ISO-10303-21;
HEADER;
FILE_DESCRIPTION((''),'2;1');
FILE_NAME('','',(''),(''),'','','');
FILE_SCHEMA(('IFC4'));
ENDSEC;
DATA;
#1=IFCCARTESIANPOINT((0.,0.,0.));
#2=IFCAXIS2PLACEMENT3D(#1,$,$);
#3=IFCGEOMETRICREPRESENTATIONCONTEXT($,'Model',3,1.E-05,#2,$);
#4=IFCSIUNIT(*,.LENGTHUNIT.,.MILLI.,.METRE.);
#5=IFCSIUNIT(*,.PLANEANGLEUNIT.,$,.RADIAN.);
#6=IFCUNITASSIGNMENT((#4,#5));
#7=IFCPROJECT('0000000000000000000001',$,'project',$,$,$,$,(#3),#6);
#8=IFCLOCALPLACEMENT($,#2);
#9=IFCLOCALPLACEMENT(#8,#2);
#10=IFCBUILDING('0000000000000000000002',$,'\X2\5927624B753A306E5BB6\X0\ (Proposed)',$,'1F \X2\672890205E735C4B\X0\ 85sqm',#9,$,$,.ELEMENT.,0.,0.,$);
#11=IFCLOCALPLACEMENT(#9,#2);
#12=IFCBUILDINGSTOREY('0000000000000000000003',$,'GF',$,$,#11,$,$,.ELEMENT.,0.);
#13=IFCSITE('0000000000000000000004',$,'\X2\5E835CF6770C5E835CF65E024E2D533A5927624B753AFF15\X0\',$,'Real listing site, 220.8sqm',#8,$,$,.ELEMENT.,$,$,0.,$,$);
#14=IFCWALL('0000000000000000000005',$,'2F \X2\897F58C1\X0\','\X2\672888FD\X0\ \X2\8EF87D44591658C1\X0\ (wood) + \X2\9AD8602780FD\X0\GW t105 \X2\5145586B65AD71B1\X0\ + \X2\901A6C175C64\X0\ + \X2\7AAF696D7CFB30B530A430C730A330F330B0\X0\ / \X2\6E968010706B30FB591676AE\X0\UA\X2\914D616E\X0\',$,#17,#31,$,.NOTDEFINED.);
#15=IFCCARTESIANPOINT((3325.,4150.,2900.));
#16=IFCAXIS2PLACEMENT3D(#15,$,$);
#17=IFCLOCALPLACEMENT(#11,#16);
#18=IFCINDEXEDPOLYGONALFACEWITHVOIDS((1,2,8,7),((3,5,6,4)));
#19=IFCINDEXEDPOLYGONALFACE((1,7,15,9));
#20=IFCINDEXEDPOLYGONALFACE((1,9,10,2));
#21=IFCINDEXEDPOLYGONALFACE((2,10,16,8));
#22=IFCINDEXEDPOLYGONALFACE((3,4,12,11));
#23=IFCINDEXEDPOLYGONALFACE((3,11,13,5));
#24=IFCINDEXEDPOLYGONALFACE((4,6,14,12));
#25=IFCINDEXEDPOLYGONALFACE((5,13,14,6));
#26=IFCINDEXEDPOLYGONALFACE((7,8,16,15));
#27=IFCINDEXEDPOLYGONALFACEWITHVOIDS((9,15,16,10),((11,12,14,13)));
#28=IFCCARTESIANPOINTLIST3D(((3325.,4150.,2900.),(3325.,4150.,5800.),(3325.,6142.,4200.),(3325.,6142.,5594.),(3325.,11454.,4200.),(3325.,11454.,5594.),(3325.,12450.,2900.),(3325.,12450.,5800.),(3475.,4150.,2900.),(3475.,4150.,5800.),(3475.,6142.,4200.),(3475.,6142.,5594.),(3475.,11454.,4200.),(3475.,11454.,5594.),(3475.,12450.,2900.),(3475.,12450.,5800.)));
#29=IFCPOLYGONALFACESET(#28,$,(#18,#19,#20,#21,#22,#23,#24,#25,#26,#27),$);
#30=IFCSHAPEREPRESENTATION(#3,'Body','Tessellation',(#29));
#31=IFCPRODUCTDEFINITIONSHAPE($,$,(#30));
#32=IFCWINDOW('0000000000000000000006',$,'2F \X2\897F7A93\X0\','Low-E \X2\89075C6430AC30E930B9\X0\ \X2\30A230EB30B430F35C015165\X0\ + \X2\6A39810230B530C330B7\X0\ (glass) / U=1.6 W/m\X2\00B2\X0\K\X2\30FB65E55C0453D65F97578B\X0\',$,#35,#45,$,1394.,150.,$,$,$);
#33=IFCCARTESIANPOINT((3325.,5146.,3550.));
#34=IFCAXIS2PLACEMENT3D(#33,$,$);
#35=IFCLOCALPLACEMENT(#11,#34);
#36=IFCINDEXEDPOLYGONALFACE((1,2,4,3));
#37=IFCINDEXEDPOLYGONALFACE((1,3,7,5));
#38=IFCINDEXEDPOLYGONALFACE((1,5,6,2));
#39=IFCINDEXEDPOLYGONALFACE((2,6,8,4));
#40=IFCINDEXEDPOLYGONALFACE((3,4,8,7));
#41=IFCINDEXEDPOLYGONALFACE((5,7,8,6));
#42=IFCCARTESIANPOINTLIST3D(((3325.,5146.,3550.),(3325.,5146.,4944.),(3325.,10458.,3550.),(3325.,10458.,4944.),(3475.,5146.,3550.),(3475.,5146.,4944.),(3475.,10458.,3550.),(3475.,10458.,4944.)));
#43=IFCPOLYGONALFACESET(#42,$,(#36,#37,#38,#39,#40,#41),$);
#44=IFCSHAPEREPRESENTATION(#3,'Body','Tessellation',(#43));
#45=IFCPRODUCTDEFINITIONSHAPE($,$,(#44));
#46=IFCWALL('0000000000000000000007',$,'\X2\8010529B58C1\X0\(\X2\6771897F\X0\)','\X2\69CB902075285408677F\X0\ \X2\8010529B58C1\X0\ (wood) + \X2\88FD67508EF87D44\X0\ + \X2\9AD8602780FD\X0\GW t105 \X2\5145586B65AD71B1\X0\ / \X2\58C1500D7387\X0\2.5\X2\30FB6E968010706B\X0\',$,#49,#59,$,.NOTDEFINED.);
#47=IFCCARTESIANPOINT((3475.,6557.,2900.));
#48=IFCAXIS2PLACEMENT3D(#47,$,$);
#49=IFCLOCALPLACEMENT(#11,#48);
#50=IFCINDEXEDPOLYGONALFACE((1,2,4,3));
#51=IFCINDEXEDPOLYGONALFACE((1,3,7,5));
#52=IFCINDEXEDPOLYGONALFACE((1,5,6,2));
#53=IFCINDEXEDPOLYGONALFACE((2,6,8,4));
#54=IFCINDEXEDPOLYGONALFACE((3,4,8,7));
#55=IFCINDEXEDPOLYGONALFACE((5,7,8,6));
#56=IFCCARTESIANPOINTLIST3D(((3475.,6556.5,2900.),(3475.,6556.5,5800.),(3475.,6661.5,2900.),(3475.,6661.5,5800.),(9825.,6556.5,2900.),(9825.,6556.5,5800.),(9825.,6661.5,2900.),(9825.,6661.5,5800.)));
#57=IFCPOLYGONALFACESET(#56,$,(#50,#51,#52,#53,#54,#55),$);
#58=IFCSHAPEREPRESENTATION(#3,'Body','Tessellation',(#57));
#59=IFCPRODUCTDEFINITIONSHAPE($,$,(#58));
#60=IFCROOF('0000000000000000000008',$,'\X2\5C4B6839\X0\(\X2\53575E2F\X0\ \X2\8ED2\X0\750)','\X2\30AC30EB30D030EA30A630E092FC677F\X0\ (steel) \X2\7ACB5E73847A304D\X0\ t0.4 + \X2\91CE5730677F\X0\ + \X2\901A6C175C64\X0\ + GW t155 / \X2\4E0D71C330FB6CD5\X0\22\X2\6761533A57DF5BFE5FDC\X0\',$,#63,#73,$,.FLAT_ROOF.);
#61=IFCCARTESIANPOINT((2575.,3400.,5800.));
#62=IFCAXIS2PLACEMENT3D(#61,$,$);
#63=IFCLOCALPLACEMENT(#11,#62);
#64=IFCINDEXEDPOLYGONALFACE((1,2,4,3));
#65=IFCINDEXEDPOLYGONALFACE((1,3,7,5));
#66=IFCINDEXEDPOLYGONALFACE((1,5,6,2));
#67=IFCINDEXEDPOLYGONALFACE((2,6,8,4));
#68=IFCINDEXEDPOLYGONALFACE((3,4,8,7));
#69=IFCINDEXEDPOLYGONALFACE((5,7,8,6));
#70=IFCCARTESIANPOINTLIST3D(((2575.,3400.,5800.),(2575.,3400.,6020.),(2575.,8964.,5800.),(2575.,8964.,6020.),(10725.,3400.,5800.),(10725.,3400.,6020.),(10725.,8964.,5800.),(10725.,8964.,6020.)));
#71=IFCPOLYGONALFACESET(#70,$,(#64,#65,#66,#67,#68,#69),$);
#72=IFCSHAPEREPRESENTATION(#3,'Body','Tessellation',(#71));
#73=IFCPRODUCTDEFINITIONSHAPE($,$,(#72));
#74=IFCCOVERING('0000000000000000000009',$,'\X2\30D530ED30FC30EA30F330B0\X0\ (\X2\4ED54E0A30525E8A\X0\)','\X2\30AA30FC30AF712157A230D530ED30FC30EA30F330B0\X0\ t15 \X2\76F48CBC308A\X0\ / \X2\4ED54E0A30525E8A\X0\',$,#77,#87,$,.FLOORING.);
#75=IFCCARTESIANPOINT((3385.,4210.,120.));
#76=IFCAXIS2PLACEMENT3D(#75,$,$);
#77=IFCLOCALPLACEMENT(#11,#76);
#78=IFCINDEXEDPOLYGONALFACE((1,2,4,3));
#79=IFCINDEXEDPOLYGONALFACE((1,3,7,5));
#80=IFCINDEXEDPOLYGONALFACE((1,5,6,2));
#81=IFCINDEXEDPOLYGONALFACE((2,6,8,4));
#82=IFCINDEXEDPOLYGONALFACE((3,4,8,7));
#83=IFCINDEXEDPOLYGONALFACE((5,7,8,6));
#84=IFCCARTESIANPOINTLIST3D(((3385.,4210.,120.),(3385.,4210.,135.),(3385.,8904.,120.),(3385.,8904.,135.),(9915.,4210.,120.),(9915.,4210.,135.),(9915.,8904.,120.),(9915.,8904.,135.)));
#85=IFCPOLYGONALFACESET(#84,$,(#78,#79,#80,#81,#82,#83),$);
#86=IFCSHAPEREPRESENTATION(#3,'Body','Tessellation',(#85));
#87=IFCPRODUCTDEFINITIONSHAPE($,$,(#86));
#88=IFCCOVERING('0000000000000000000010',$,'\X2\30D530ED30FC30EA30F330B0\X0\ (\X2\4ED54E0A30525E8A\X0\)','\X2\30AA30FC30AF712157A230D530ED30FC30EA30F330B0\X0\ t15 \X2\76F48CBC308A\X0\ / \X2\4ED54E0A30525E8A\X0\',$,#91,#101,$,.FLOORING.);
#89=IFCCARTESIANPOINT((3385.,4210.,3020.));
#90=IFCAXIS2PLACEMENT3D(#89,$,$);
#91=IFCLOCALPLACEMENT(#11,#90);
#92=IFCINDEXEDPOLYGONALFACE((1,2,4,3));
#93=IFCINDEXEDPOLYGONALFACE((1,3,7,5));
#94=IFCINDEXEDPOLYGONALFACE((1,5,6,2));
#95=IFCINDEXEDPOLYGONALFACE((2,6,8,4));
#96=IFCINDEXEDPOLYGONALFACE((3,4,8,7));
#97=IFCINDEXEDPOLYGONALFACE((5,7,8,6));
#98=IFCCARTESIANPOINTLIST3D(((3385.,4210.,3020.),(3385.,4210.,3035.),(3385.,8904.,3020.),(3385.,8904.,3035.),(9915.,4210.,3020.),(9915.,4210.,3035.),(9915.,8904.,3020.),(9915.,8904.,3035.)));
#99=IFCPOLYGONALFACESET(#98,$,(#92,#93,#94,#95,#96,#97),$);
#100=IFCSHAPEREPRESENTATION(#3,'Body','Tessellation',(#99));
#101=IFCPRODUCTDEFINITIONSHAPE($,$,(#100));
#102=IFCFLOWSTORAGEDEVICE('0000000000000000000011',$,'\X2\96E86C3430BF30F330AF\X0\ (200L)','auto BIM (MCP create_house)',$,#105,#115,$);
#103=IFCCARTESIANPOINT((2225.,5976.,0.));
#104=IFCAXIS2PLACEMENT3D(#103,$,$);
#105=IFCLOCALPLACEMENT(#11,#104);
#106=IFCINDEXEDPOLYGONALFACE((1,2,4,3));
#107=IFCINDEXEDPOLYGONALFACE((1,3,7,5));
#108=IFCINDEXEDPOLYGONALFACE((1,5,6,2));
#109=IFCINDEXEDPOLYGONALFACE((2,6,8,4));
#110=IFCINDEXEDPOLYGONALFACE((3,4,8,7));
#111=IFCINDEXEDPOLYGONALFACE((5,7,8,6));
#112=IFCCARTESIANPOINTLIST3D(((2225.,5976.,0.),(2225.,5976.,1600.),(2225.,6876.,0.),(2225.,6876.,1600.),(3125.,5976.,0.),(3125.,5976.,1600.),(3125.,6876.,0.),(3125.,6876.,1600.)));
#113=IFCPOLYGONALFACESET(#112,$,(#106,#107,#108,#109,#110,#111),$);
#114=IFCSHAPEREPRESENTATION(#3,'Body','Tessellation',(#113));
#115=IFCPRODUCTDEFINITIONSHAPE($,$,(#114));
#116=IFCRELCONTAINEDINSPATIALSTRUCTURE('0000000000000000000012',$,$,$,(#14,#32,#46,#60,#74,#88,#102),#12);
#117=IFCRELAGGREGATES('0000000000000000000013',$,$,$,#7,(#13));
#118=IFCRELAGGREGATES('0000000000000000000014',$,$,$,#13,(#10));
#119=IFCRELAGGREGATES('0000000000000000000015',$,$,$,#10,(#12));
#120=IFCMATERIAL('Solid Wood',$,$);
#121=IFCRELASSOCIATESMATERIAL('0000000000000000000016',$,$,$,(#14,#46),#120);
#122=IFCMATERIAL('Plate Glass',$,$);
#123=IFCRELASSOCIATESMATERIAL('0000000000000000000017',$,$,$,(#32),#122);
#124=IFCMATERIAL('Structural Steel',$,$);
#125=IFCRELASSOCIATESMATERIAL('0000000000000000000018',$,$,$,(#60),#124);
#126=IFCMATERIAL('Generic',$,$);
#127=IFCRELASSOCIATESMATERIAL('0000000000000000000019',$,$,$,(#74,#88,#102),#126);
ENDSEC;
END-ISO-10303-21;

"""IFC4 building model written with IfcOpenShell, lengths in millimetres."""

from ifc_helpers import new_model, si_unit, frame, frame_2d, origin, place, context, project, spatial, rectangle, extrude, material, element, fill, save


model = new_model("IFC4")

# Units and contexts
model_context = context("Model", 3, precision=1e-05, world=origin())
ifc_project = project(units=[si_unit("LENGTHUNIT", "METRE", prefix="MILLI"), si_unit("PLANEANGLEUNIT", "RADIAN")], contexts=[model_context])

# Site, building, storey
site_placement = place(None, origin())
site = spatial("IfcSite", under=ifc_project, at=site_placement, Name="広島県広島市中区大手町５", ObjectType="Real listing site, 220.8sqm", CompositionType="ELEMENT", RefElevation=0.0)
building_placement = place(site_placement, origin())
building = spatial("IfcBuilding", under=site, at=building_placement, Name="大手町の家 (Proposed)", ObjectType="1F 木造平屋 85sqm", CompositionType="ELEMENT", ElevationOfRefHeight=0.0, ElevationOfTerrain=0.0)
storey_placement = place(building_placement, origin())
storey = spatial("IfcBuildingStorey", under=building, at=storey_placement, Name="GF", CompositionType="ELEMENT", Elevation=0.0)

# Shared definitions
ifc_material_1 = material(Name="Solid Wood")
ifc_material_2 = material(Name="Generic")

# Shared definitions
ifc_material_3 = material(Name="Plate Glass")

# Wall, opening, window
wall_1_placement = place(storey_placement, frame((3325.0, 4150.0, 2900.0)))
wall_1 = element("IfcWall", 1, at=wall_1_placement, inside=storey, material=ifc_material_1, Name="2F 西壁", Description="木製 軸組外壁 (wood) + 高性能GW t105 充填断熱 + 通気層 + 窯業系サイディング / 準耐火・外皮UA配慮", PredefinedType="NOTDEFINED", context=model_context, shape_type="SweptSolid", body=[
    extrude(rectangle(XDim=150.0, YDim=8300.0, at=frame_2d((75.0, 4150.0))), frame((3325.0, 4150.0, 2900.0)), (0.0, 0.0, 1.0), 2900.0),
])
opening_1_placement = place(storey_placement, frame((3325.0, 5146.0, 3550.0)))
opening_1 = element("IfcOpeningElement", 2, at=opening_1_placement, cuts=wall_1, PredefinedType="NOTDEFINED", context=model_context, shape_type="SweptSolid", body=[
    extrude(rectangle(XDim=150.0, YDim=5312.0, at=frame_2d((75.0, 2656.0))), frame((3325.0, 5146.0, 3550.0)), (0.0, 0.0, 1.0), 1394.0),
])
window_1_placement = place(storey_placement, frame((3325.0, 5146.0, 3550.0)))
window_1 = element("IfcWindow", 3, at=window_1_placement, inside=storey, material=ifc_material_3, Name="2F 西窓", Description="Low-E 複層ガラス アルゴン封入 + 樹脂サッシ (glass) / U=1.6 W/m²K・日射取得型", OverallHeight=1394.0, OverallWidth=150.0, context=model_context, shape_type="SweptSolid", body=[
    extrude(rectangle(XDim=150.0, YDim=5312.0, at=frame_2d((75.0, 2656.0))), frame((3325.0, 5146.0, 3550.0)), (0.0, 0.0, 1.0), 1394.0),
])
fill(opening_1, window_1)

# Wall
wall_2_placement = place(storey_placement, frame((3475.0, 6557.0, 2900.0)))
element("IfcWall", 4, at=wall_2_placement, inside=storey, material=ifc_material_1, Name="耐力壁(東西)", Description="構造用合板 耐力壁 (wood) + 製材軸組 + 高性能GW t105 充填断熱 / 壁倍率2.5・準耐火", PredefinedType="NOTDEFINED", context=model_context, shape_type="SweptSolid", body=[
    extrude(rectangle(XDim=6350.0, YDim=105.0, at=frame_2d((3175.0, 52.0))), frame((3475.0, 6557.0, 2900.0)), (0.0, 0.0, 1.0), 2900.0),
])

# Roof
ifc_material_4 = material(Name="Structural Steel")
for number, where, name in (
    (5, (2575.0, 3400.0, 5800.0), "屋根(南帯 軒750)"),
):
    element("IfcRoof", number, at=place(storey_placement, frame(where)), inside=storey, material=ifc_material_4, Name=name, Description="ガルバリウム鋼板 (steel) 立平葺き t0.4 + 野地板 + 通気層 + GW t155 / 不燃・法22条区域対応", PredefinedType="FLAT_ROOF", context=model_context, shape_type="SweptSolid", body=[
        extrude(rectangle(XDim=8150.0, YDim=5564.0, at=frame_2d((4075.0, 2782.0))), frame((2575.0, 3400.0, 5800.0)), (0.0, 0.0, 1.0), 220.0),
    ])

# Coverings
covering_1_placement = place(storey_placement, frame((3385.0, 4210.0, 120.0)))
element("IfcCovering", 6, at=covering_1_placement, inside=storey, material=ifc_material_2, Name="フローリング (仕上げ床)", Description="オーク無垢フローリング t15 直貼り / 仕上げ床", PredefinedType="FLOORING", context=model_context, shape_type="SweptSolid", body=[
    extrude(rectangle(XDim=6530.0, YDim=4694.0, at=frame_2d((3265.0, 2347.0))), frame((3385.0, 4210.0, 120.0)), (0.0, 0.0, 1.0), 15.0),
])
covering_2_placement = place(storey_placement, frame((3385.0, 4210.0, 3020.0)))
element("IfcCovering", 7, at=covering_2_placement, inside=storey, material=ifc_material_2, Name="フローリング (仕上げ床)", Description="オーク無垢フローリング t15 直貼り / 仕上げ床", PredefinedType="FLOORING", context=model_context, shape_type="SweptSolid", body=[
    extrude(rectangle(XDim=6530.0, YDim=4694.0, at=frame_2d((3265.0, 2347.0))), frame((3385.0, 4210.0, 3020.0)), (0.0, 0.0, 1.0), 15.0),
])

# Flow storage device
flow_storage_device_placement = place(storey_placement, frame((2225.0, 5976.0, 0.0)))
element("IfcFlowStorageDevice", 8, at=flow_storage_device_placement, inside=storey, material=ifc_material_2, Name="雨水タンク (200L)", Description="auto BIM (MCP create_house)", context=model_context, shape_type="SweptSolid", body=[
    extrude(rectangle(XDim=900.0, YDim=900.0, at=frame_2d((450.0, 450.0))), frame((2225.0, 5976.0, 0.0)), (0.0, 0.0, 1.0), 1600.0),
])

save(model, "model.ifc")
